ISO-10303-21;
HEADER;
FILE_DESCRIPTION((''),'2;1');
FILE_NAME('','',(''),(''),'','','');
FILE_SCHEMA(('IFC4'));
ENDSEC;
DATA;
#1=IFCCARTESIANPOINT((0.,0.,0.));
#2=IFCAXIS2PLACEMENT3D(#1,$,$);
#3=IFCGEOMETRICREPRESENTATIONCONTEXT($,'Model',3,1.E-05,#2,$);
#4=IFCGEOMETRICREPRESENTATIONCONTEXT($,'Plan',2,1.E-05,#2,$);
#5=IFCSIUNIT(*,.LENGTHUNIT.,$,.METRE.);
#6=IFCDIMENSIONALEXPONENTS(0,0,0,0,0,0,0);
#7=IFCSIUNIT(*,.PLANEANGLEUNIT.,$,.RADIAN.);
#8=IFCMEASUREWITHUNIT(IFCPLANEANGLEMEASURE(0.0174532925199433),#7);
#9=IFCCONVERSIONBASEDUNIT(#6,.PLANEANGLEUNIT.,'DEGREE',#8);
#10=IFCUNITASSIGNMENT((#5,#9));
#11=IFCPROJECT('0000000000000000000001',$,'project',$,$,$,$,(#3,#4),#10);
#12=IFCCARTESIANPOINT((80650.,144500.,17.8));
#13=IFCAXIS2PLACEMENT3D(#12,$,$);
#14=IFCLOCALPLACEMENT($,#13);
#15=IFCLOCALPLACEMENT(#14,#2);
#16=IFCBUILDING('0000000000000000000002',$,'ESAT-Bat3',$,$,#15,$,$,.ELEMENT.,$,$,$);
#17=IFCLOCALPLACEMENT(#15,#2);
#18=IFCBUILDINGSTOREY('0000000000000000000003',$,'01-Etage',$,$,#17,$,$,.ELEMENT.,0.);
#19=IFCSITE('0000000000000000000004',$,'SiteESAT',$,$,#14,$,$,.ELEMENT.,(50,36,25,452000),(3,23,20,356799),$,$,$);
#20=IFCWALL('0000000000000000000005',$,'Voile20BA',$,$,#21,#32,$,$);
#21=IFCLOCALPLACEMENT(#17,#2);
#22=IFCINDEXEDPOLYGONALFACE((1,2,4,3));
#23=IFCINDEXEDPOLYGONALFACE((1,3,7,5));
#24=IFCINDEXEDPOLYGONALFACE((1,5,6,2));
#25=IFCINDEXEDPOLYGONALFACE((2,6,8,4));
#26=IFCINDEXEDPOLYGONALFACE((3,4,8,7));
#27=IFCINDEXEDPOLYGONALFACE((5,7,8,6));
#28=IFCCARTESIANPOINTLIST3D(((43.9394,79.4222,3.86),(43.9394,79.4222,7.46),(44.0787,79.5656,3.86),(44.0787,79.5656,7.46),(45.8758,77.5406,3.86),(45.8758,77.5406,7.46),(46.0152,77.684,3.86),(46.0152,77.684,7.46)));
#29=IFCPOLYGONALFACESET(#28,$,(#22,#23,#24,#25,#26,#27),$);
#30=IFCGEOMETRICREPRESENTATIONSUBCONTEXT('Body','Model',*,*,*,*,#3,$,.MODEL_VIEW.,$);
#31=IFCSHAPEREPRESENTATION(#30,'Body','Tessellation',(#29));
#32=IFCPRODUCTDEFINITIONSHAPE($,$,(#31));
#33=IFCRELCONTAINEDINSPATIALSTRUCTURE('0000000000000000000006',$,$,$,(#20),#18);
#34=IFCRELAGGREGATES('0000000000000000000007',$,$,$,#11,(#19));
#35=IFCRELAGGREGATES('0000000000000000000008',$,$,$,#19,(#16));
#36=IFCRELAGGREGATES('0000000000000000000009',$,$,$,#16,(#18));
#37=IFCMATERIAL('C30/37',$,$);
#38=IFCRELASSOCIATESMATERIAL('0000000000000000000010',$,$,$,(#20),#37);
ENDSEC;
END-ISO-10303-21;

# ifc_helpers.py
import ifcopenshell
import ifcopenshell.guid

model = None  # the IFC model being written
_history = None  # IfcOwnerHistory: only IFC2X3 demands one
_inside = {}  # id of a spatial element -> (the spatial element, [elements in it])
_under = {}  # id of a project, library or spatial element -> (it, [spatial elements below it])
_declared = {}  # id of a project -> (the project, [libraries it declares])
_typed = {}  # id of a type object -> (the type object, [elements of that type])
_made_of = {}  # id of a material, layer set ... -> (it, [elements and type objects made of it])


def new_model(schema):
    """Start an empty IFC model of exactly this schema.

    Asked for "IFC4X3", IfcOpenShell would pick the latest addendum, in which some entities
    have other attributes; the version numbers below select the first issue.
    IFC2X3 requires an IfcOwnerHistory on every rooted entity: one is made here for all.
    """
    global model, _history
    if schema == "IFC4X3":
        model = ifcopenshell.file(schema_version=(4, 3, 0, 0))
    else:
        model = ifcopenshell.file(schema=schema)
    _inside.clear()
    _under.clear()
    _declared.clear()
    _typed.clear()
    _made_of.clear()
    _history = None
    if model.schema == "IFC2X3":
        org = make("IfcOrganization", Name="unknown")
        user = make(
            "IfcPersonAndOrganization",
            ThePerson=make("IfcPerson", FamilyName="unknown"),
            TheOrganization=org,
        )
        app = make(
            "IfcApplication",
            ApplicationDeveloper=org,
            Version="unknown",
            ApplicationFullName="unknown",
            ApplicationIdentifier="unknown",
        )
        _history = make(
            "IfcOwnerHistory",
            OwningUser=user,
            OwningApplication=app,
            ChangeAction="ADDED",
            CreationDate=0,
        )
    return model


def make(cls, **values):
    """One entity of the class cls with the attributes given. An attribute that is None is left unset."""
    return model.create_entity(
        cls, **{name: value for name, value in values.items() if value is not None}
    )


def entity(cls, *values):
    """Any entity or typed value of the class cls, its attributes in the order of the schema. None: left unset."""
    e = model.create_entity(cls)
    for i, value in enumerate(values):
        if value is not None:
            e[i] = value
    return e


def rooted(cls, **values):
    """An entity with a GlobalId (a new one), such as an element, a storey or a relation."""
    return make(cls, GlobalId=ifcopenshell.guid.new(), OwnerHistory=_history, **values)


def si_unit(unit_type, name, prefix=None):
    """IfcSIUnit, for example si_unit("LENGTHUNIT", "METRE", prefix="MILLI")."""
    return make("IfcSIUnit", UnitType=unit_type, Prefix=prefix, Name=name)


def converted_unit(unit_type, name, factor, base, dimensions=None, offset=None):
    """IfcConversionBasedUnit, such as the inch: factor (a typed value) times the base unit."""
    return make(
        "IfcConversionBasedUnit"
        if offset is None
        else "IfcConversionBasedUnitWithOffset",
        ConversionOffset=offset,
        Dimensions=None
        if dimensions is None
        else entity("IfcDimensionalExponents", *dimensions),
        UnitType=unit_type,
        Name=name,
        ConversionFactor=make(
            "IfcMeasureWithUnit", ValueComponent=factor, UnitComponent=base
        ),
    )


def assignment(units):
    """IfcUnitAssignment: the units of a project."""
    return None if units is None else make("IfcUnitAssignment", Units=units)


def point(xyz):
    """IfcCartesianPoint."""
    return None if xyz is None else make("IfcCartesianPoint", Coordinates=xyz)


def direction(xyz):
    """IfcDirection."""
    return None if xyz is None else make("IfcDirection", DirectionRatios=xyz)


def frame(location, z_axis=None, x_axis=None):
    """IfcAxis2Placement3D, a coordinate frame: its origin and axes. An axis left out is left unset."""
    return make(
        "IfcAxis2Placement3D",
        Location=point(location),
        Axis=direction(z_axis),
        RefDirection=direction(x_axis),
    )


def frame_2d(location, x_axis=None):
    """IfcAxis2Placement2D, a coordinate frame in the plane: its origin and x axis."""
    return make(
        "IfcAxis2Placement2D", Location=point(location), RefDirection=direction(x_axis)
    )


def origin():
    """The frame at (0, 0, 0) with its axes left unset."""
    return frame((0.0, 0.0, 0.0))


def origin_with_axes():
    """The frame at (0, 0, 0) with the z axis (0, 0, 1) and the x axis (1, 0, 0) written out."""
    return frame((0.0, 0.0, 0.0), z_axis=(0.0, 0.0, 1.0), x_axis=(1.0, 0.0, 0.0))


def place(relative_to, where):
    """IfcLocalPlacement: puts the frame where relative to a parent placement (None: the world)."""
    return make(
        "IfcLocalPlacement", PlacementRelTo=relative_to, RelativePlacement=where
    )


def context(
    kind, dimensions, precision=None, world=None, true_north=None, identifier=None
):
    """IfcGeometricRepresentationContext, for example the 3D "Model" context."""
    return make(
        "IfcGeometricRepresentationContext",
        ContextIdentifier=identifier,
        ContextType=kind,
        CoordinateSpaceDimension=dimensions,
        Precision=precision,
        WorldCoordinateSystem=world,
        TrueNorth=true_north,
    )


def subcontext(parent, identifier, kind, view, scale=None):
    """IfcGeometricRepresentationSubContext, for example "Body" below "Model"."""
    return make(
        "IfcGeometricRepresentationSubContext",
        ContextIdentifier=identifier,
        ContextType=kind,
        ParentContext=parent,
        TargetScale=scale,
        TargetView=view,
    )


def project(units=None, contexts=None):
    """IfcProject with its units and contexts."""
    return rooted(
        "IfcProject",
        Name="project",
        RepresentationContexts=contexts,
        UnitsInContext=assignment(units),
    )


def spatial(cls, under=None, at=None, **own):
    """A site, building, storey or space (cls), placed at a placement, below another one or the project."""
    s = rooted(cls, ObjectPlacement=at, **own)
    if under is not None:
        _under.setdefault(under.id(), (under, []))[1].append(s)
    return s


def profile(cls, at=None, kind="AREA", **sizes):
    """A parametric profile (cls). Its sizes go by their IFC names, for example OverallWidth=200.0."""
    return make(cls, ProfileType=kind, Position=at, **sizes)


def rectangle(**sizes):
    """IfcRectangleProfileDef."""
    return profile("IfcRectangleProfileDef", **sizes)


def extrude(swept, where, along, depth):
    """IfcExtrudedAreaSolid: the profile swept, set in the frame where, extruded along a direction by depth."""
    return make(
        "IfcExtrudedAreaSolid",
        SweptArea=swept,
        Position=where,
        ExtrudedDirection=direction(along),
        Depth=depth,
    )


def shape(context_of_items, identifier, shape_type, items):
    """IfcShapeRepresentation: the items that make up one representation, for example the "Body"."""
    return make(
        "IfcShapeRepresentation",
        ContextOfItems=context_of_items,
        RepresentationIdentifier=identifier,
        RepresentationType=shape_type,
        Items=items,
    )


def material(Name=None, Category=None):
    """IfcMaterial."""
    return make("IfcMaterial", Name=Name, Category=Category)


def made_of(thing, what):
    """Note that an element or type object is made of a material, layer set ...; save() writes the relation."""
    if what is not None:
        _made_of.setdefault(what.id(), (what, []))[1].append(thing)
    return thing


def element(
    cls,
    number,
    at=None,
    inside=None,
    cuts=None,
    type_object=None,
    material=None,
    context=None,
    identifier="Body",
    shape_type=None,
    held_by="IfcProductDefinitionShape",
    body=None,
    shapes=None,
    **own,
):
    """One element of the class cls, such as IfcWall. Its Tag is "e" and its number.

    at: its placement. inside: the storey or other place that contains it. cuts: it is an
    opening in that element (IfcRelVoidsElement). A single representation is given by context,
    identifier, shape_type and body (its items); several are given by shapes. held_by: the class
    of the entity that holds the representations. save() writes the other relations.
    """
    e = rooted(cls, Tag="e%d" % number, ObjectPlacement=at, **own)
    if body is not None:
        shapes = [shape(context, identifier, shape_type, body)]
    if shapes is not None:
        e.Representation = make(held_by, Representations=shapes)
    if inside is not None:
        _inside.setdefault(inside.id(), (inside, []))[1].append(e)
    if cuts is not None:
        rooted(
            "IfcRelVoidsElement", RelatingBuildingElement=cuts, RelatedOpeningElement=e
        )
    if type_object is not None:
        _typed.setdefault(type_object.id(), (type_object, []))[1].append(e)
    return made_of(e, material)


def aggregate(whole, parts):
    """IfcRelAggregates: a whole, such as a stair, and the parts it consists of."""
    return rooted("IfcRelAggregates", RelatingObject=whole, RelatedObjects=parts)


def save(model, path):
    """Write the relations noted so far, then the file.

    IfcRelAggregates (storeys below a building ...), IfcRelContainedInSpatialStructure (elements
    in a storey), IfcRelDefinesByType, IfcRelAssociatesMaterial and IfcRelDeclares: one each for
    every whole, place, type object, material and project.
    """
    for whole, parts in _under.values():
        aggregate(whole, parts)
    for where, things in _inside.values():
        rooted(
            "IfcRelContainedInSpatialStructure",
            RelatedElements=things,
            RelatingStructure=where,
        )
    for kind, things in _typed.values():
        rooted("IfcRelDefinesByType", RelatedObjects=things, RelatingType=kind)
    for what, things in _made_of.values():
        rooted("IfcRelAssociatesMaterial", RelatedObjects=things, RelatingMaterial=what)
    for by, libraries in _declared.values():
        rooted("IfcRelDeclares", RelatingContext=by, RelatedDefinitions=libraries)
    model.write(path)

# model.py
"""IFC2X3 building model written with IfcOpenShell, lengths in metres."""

from ifc_helpers import new_model, entity, si_unit, converted_unit, frame, frame_2d, origin, origin_with_axes, place, context, subcontext, project, spatial, rectangle, extrude, material, element, save


model = new_model("IFC2X3")

# Units and contexts
model_context = context("Model", 3, precision=1e-05, world=origin())
plan_context = context("Plan", 2, precision=1e-05, world=origin())
body_context = subcontext(model_context, "Body", "Model", "MODEL_VIEW")
ifc_project = project(units=[si_unit("LENGTHUNIT", "METRE"), converted_unit("PLANEANGLEUNIT", "DEGREE", entity("IfcPlaneAngleMeasure", 0.0174532925199433), si_unit("PLANEANGLEUNIT", "RADIAN"), dimensions=[0, 0, 0, 0, 0, 0, 0])], contexts=[model_context, plan_context])

# Site, building, storey
site_placement = place(None, frame((80650.0, 144500.0, 17.8)))
site = spatial("IfcSite", under=ifc_project, at=site_placement, Name="SiteESAT", CompositionType="ELEMENT", RefLatitude=(50, 36, 25, 452000), RefLongitude=(3, 23, 20, 356799))
building_placement = place(site_placement, origin())
building = spatial("IfcBuilding", under=site, at=building_placement, Name="ESAT-Bat3", CompositionType="ELEMENT")
storey_placement = place(building_placement, origin())
storey = spatial("IfcBuildingStorey", under=building, at=storey_placement, Name="01-Etage", CompositionType="ELEMENT", Elevation=0.0)

# Wall
ifc_material_1 = material(Name="C30/37")
wall_1_placement = place(storey_placement, frame((46.0152, 77.684, 3.86), z_axis=(0.0, 0.0, 1.0), x_axis=(-0.717196, 0.696872, 0.0)))
element("IfcWall", 1, at=wall_1_placement, inside=storey, material=ifc_material_1, Name="Voile20BA", context=body_context, shape_type="SweptSolid", body=[
    extrude(rectangle(XDim=2.7, YDim=0.2, at=frame_2d((1.35, 0.1), x_axis=(1.0, 0.0))), origin_with_axes(), (0.0, 0.0, 1.0), 3.6),
])

save(model, "model.ifc")
